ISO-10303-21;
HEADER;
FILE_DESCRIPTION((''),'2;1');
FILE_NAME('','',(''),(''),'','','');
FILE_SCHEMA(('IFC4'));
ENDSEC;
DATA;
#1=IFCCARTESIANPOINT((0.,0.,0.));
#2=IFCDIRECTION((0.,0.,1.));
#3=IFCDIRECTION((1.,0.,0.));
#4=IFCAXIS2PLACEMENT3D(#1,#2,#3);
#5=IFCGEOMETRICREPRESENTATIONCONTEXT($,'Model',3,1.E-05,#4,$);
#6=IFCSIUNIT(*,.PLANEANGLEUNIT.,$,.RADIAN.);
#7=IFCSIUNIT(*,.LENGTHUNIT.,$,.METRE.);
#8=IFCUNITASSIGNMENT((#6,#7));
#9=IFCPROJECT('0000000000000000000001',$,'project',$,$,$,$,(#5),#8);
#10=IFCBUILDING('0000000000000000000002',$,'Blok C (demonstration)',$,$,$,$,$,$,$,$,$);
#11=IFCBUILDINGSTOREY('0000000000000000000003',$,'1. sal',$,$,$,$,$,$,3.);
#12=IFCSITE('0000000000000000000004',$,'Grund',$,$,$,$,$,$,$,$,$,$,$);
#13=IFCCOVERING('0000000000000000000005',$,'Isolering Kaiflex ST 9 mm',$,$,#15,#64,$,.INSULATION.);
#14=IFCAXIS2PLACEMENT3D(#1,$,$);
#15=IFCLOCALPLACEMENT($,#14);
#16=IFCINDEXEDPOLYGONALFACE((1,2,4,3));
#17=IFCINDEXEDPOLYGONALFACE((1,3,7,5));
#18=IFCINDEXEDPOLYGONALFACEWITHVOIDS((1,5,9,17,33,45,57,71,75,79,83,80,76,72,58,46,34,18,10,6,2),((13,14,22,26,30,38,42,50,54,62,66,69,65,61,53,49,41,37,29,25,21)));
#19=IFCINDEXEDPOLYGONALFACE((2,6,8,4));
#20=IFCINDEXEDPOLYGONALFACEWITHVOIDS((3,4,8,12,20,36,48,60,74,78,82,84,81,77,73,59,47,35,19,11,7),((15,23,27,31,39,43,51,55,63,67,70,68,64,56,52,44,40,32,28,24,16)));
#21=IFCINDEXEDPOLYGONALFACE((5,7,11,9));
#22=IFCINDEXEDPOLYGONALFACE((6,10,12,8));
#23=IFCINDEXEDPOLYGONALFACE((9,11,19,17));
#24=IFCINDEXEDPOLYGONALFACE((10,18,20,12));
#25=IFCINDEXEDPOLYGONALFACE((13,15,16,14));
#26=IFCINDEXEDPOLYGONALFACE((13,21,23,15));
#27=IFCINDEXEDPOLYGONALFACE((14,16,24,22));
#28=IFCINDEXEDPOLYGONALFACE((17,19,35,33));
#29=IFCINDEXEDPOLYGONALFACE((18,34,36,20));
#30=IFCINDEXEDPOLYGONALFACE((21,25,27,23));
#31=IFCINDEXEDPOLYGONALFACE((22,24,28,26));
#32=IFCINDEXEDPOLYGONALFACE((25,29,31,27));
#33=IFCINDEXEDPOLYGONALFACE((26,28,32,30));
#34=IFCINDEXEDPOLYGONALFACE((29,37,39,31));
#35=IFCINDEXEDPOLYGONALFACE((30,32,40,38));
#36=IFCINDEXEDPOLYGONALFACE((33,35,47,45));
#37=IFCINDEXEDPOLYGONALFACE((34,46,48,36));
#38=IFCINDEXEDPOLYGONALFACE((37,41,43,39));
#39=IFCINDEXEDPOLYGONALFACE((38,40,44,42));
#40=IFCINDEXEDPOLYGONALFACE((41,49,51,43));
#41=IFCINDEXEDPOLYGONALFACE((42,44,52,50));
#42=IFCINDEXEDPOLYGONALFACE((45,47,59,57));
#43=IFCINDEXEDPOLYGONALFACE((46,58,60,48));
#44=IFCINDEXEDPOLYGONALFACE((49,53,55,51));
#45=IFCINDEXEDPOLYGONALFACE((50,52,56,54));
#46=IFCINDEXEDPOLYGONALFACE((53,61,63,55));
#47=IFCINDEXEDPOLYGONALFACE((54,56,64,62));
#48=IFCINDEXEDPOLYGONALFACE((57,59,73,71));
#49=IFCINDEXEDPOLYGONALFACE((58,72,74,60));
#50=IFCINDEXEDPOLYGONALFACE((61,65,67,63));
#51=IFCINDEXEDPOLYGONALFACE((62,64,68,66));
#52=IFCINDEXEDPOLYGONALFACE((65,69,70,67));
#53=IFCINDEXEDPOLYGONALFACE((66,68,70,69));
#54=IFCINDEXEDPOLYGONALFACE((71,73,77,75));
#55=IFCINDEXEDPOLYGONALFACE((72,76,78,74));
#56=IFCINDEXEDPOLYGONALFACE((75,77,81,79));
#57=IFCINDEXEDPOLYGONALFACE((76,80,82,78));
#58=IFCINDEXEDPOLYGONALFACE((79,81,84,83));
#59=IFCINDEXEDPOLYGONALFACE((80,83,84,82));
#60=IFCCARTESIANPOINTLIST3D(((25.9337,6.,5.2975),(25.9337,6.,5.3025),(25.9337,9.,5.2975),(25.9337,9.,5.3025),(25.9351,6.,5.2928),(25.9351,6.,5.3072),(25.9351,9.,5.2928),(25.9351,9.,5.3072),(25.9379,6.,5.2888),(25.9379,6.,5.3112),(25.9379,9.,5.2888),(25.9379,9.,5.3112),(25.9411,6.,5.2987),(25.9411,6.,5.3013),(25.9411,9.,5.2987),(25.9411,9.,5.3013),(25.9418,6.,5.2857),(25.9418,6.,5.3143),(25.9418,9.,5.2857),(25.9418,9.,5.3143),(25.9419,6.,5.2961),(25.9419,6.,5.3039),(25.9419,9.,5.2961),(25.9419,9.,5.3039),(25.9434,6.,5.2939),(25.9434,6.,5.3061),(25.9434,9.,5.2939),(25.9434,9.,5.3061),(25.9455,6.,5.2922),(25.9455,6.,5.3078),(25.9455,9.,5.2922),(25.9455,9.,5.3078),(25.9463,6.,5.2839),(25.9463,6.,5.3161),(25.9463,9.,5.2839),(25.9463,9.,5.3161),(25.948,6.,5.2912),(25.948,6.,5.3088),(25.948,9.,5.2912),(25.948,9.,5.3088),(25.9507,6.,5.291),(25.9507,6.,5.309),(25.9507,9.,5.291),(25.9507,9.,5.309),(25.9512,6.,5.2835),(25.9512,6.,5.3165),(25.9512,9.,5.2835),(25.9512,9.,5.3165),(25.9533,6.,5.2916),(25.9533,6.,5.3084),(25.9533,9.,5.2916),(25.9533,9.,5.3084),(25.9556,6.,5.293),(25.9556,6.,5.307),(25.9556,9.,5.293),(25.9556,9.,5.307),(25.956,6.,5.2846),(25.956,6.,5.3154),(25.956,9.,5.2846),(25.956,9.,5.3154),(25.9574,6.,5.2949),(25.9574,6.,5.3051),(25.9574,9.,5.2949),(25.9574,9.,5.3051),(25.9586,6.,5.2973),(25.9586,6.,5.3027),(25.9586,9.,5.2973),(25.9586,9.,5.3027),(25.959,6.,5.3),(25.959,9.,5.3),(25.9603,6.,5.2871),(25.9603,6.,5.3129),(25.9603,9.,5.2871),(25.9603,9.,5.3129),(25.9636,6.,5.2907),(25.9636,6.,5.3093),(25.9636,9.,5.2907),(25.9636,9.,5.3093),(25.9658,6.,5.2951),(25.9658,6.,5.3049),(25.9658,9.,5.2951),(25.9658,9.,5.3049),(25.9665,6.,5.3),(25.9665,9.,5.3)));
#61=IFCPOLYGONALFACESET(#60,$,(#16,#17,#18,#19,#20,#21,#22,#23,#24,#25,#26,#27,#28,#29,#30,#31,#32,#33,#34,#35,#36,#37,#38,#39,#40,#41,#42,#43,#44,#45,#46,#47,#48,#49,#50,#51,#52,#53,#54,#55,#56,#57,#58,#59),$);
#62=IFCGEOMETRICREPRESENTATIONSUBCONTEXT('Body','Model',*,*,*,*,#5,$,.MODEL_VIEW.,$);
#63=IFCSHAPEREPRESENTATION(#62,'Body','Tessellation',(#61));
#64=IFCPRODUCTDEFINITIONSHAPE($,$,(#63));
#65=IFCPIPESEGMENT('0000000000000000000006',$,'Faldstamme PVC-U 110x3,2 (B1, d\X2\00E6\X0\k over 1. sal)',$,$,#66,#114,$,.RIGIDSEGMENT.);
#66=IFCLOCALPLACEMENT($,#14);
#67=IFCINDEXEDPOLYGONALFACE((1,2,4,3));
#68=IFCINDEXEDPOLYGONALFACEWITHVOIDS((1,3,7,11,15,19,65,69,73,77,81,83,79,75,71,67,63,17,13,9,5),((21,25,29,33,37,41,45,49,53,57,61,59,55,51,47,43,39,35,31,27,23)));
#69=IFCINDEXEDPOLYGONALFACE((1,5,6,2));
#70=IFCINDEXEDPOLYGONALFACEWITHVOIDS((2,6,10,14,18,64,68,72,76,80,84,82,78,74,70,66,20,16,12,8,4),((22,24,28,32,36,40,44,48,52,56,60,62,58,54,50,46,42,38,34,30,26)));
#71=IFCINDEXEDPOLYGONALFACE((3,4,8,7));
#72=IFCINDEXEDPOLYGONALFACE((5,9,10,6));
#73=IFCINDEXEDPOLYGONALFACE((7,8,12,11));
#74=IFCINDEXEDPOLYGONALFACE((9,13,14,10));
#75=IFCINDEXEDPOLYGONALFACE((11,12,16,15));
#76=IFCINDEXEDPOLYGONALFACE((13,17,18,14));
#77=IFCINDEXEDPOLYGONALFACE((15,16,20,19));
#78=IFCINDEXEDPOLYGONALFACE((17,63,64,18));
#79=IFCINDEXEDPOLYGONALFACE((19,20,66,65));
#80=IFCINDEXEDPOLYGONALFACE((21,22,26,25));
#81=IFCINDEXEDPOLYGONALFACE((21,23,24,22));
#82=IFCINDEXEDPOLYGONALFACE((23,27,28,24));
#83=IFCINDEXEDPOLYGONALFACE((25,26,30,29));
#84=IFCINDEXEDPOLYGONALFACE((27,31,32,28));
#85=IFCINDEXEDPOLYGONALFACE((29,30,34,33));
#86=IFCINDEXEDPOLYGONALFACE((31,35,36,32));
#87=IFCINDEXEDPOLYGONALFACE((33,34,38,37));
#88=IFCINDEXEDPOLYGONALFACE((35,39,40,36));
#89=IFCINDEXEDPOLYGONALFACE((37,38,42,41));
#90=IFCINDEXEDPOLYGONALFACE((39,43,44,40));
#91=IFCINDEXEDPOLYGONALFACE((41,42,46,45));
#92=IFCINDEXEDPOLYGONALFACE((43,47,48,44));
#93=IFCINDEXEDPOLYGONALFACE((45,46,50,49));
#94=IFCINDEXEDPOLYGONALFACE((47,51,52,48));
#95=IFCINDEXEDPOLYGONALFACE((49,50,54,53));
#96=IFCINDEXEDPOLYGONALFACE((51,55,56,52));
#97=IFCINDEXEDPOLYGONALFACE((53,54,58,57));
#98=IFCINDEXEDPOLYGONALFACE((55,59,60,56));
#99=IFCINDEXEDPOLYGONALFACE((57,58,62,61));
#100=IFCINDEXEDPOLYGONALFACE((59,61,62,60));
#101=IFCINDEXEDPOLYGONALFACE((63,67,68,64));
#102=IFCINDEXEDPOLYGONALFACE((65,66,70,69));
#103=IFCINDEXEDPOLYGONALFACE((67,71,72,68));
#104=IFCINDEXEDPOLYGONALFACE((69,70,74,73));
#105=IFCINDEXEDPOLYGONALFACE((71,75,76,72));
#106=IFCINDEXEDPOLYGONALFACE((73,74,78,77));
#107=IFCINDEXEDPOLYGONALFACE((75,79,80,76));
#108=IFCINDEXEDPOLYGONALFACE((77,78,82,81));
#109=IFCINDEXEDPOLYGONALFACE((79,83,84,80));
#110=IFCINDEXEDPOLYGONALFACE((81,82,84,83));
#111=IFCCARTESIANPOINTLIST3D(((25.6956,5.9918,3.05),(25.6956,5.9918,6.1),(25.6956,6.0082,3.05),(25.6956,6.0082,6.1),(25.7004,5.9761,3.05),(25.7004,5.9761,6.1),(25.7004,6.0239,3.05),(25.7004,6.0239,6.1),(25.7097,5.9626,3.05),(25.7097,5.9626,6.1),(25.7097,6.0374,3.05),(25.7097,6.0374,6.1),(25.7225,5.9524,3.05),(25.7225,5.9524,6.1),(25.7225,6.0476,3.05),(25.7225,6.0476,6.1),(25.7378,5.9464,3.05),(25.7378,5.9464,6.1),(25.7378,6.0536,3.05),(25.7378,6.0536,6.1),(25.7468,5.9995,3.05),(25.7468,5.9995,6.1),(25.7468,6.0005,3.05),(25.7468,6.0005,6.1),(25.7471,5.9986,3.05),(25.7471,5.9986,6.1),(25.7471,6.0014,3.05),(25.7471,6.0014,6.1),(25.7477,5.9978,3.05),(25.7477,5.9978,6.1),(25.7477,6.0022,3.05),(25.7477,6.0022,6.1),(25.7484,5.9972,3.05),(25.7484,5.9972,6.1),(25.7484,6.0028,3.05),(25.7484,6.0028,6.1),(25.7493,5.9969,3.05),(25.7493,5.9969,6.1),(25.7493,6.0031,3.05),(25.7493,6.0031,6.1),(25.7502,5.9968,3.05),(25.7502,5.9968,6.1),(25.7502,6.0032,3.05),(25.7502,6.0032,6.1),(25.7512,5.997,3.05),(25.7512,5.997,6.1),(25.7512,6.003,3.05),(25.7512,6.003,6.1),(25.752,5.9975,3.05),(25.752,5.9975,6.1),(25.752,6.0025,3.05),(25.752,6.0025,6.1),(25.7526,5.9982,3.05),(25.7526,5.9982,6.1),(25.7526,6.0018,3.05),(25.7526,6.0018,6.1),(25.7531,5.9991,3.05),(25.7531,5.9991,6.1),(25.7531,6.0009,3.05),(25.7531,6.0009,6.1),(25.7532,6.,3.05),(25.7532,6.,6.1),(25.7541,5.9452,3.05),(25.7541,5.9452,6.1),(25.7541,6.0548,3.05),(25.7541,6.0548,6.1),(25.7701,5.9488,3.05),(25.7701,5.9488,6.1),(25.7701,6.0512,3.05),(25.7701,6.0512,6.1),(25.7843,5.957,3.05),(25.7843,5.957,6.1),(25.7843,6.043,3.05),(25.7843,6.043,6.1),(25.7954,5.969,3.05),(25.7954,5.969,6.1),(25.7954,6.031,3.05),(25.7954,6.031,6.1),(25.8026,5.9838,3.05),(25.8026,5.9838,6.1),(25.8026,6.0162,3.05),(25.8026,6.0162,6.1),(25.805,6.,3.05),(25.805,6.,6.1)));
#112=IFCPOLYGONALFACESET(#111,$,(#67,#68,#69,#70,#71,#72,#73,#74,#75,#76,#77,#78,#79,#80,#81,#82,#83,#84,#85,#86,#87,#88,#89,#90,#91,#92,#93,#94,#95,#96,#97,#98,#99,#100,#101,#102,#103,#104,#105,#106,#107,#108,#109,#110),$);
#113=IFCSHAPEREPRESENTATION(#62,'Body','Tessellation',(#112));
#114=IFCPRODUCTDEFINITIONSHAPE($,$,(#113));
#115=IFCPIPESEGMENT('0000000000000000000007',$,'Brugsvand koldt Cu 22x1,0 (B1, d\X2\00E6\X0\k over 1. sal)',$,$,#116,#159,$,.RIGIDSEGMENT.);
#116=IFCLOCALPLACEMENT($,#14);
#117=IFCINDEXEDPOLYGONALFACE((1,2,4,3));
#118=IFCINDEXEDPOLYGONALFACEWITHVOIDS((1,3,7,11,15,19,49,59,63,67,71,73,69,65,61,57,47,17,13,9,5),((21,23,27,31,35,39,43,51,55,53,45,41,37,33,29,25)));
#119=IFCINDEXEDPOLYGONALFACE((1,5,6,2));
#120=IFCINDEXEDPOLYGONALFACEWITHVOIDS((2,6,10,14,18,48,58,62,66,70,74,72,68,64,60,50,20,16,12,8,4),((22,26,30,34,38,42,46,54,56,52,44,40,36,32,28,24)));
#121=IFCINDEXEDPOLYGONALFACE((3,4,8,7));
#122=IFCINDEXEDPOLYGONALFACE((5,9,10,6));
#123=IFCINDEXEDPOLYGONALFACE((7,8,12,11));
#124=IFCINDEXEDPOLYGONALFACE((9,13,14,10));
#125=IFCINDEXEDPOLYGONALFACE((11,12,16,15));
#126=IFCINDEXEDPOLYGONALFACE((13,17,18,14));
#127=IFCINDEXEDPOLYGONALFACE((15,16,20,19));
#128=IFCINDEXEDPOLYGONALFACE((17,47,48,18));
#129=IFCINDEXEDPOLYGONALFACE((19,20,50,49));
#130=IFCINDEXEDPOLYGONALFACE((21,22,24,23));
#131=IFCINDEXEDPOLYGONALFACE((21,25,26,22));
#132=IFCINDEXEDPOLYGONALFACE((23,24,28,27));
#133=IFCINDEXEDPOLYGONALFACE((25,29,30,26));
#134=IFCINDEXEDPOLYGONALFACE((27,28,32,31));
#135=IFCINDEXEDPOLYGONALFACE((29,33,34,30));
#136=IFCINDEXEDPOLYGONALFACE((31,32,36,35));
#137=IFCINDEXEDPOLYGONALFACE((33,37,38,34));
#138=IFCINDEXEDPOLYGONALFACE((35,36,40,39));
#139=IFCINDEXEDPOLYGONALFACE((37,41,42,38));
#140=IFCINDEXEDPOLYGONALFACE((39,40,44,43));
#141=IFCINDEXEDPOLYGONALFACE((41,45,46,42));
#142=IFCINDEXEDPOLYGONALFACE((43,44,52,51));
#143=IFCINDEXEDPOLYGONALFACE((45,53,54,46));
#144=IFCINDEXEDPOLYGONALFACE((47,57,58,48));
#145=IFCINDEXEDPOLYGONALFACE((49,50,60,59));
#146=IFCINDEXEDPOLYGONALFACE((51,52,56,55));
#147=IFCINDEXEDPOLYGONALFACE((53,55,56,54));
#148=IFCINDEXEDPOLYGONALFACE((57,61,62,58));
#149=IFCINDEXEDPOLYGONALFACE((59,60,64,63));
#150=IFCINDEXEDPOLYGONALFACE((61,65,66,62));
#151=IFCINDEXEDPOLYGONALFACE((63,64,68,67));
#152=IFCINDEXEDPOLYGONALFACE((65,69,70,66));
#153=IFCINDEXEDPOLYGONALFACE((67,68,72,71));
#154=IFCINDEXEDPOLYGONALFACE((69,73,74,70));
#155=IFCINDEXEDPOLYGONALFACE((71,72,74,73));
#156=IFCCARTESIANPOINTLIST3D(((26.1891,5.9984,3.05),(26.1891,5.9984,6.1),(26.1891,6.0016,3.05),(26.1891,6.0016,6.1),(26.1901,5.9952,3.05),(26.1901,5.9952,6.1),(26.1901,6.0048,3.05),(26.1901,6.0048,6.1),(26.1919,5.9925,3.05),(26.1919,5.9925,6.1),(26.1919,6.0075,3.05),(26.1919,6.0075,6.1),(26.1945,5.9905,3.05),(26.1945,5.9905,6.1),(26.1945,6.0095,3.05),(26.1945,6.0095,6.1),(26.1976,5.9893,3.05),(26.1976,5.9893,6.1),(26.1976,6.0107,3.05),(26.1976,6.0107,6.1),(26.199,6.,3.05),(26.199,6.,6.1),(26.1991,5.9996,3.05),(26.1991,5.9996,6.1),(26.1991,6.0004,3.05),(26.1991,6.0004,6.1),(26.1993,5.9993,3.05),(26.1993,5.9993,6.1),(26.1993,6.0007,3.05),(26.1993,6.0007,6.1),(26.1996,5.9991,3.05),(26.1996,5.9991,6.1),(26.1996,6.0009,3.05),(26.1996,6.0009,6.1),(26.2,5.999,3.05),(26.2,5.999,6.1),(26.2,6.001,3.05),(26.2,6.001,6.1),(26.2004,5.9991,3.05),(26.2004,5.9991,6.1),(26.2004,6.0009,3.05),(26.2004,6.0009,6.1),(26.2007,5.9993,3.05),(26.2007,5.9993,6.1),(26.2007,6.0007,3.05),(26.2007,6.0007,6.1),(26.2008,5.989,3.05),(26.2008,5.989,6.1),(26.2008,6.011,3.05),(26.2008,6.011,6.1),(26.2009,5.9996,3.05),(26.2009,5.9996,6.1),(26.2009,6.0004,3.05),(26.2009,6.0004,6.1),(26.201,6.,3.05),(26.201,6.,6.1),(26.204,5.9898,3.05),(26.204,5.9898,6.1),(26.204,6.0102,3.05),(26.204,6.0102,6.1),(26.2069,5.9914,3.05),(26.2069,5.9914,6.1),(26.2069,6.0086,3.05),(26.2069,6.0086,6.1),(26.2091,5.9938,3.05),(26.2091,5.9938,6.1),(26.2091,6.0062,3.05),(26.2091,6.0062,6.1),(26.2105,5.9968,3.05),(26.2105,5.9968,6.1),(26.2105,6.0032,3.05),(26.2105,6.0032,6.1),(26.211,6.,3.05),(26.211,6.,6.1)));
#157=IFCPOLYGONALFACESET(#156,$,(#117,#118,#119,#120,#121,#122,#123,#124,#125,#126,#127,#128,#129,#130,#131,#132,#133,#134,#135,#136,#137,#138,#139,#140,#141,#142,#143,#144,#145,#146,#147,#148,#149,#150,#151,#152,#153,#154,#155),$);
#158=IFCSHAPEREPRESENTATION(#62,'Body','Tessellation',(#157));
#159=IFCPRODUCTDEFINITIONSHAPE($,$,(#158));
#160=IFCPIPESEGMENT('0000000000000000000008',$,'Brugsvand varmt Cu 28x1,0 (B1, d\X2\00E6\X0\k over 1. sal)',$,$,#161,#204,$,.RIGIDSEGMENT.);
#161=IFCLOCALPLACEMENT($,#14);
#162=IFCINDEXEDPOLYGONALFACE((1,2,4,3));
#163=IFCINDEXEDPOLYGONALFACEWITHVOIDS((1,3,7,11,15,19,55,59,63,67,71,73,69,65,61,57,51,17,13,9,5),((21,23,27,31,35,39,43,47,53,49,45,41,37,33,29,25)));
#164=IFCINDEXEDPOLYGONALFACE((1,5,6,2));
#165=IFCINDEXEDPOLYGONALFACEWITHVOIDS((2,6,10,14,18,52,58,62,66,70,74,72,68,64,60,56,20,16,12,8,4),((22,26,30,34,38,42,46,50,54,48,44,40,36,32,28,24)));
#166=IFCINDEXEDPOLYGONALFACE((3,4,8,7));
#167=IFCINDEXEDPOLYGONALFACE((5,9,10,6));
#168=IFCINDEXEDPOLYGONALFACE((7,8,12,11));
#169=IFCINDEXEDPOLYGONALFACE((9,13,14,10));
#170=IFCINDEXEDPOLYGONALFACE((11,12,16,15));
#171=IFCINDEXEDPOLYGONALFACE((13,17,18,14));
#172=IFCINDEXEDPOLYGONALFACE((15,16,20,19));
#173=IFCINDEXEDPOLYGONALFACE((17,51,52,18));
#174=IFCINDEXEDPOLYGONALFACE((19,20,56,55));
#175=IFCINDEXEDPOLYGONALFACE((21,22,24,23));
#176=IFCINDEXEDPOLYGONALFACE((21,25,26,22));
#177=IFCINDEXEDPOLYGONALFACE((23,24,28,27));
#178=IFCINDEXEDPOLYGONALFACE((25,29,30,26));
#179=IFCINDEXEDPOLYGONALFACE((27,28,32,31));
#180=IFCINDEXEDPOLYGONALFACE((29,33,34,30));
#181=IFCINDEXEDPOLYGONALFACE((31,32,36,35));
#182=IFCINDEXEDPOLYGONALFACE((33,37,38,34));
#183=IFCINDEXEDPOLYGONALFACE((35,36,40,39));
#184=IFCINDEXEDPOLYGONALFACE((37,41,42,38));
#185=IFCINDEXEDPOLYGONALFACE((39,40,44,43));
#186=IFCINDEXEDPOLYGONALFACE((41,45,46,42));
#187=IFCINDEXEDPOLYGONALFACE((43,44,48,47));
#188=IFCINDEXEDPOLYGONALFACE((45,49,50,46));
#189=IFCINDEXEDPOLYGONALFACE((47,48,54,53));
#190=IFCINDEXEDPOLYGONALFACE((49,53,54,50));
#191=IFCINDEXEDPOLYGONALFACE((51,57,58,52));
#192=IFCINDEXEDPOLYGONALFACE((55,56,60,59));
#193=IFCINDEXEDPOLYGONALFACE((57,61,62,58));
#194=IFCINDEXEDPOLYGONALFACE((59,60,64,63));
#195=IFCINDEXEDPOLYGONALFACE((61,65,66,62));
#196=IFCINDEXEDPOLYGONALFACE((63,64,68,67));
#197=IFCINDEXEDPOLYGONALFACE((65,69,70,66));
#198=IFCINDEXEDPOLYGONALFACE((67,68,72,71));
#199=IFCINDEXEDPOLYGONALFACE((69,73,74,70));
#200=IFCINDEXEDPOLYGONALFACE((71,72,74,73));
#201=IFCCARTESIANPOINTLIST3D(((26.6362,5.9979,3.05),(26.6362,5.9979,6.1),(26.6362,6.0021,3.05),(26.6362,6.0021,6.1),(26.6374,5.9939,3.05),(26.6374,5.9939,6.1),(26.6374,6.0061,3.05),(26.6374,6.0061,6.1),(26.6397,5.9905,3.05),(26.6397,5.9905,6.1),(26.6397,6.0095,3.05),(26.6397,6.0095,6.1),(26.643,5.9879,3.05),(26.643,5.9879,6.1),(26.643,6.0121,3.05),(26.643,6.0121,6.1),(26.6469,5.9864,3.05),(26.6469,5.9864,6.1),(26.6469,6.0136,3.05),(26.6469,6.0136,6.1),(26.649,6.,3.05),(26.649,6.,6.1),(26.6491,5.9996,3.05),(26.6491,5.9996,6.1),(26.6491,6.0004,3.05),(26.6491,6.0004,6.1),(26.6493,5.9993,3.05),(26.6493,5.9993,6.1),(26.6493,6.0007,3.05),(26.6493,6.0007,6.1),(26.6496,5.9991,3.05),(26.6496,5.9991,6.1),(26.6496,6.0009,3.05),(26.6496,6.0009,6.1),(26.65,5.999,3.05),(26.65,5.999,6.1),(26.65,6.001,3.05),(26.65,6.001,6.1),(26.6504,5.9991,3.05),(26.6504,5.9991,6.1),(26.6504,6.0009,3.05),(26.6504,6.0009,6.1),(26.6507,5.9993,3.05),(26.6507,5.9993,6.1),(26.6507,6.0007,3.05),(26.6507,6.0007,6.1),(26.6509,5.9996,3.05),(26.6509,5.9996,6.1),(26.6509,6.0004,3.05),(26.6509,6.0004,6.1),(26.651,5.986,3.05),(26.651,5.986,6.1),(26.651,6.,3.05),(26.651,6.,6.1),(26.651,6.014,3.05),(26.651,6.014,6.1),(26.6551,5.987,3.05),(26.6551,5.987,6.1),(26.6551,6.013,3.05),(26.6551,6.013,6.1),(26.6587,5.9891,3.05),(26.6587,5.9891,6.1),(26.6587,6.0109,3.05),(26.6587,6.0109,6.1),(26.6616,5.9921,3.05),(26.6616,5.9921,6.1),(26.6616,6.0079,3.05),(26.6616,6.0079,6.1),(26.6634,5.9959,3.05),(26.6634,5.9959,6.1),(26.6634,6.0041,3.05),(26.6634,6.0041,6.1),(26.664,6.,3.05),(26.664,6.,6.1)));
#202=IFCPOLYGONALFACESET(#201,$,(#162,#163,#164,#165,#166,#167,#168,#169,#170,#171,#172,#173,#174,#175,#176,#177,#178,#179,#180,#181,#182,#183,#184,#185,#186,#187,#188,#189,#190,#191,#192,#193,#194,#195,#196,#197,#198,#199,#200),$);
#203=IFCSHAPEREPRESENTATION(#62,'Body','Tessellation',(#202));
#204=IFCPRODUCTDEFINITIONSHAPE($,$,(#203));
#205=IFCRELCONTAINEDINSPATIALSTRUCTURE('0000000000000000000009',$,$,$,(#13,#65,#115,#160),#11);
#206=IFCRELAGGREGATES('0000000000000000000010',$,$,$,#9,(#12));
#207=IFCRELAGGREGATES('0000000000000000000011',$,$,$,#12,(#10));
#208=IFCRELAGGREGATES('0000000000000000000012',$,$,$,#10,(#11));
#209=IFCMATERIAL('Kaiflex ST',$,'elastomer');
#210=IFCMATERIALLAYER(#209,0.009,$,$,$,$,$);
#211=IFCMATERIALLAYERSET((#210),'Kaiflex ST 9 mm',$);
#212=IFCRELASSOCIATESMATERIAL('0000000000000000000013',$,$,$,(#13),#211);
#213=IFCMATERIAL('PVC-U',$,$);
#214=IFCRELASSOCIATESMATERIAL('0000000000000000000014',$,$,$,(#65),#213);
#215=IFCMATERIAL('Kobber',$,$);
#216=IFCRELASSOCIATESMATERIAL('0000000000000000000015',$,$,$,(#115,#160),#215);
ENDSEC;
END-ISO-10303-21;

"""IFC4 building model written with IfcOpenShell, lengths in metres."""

from ifc_helpers import new_model, si_unit, frame, origin_with_axes, place, context, subcontext, project, spatial, hollow_circle, extrude, material, layer, layer_set, element, save


model = new_model("IFC4")

# Units and contexts
model_context = context("Model", 3, precision=1e-05, world=origin_with_axes())
body_context = subcontext(model_context, "Body", "Model", "MODEL_VIEW")
ifc_project = project(units=[si_unit("PLANEANGLEUNIT", "RADIAN"), si_unit("LENGTHUNIT", "METRE")], contexts=[model_context])

# Site, building, storey
site = spatial("IfcSite", under=ifc_project, Name="Grund")
building = spatial("IfcBuilding", under=site, Name="Blok C (demonstration)")
storey = spatial("IfcBuildingStorey", under=building, Name="1. sal", Elevation=3.0)

# Covering
ifc_material_1 = material(Name="Kaiflex ST", Category="elastomer")
ifc_layer_1 = layer(ifc_material_1, 0.009)
ifc_layer_set_1 = layer_set([ifc_layer_1], Name="Kaiflex ST 9 mm")
covering_1_placement = place(None, origin_with_axes())
element("IfcCovering", 1, at=covering_1_placement, inside=storey, material=ifc_layer_set_1, Name="Isolering Kaiflex ST 9 mm", PredefinedType="INSULATION", context=body_context, shape_type="SweptSolid", body=[
    extrude(hollow_circle(Radius=0.0165, WallThickness=0.0075), frame((25.95, 6.0, 5.3), z_axis=(0.0, 1.0, 0.0), x_axis=(1.0, 0.0, 0.0)), (0.0, 0.0, 1.0), 3.0),
])

# Pipe segments
ifc_material_2 = material(Name="PVC-U")
pipe_segment_1_placement = place(None, origin_with_axes())
element("IfcPipeSegment", 2, at=pipe_segment_1_placement, inside=storey, material=ifc_material_2, Name="Faldstamme PVC-U 110x3,2 (B1, dæk over 1. sal)", PredefinedType="RIGIDSEGMENT", context=body_context, shape_type="SweptSolid", body=[
    extrude(hollow_circle(Radius=0.055, WallThickness=0.0518), frame((25.75, 6.0, 3.05), z_axis=(0.0, 0.0, 1.0), x_axis=(1.0, 0.0, 0.0)), (0.0, 0.0, 1.0), 3.05),
])
ifc_material_3 = material(Name="Kobber")
pipe_segment_2_placement = place(None, origin_with_axes())
element("IfcPipeSegment", 3, at=pipe_segment_2_placement, inside=storey, material=ifc_material_3, Name="Brugsvand koldt Cu 22x1,0 (B1, dæk over 1. sal)", PredefinedType="RIGIDSEGMENT", context=body_context, shape_type="SweptSolid", body=[
    extrude(hollow_circle(Radius=0.011, WallThickness=0.01), frame((26.2, 6.0, 3.05), z_axis=(0.0, 0.0, 1.0), x_axis=(1.0, 0.0, 0.0)), (0.0, 0.0, 1.0), 3.05),
])
pipe_segment_3_placement = place(None, origin_with_axes())
element("IfcPipeSegment", 4, at=pipe_segment_3_placement, inside=storey, material=ifc_material_3, Name="Brugsvand varmt Cu 28x1,0 (B1, dæk over 1. sal)", PredefinedType="RIGIDSEGMENT", context=body_context, shape_type="SweptSolid", body=[
    extrude(hollow_circle(Radius=0.014, WallThickness=0.013), frame((26.65, 6.0, 3.05), z_axis=(0.0, 0.0, 1.0), x_axis=(1.0, 0.0, 0.0)), (0.0, 0.0, 1.0), 3.05),
])

save(model, "model.ifc")
